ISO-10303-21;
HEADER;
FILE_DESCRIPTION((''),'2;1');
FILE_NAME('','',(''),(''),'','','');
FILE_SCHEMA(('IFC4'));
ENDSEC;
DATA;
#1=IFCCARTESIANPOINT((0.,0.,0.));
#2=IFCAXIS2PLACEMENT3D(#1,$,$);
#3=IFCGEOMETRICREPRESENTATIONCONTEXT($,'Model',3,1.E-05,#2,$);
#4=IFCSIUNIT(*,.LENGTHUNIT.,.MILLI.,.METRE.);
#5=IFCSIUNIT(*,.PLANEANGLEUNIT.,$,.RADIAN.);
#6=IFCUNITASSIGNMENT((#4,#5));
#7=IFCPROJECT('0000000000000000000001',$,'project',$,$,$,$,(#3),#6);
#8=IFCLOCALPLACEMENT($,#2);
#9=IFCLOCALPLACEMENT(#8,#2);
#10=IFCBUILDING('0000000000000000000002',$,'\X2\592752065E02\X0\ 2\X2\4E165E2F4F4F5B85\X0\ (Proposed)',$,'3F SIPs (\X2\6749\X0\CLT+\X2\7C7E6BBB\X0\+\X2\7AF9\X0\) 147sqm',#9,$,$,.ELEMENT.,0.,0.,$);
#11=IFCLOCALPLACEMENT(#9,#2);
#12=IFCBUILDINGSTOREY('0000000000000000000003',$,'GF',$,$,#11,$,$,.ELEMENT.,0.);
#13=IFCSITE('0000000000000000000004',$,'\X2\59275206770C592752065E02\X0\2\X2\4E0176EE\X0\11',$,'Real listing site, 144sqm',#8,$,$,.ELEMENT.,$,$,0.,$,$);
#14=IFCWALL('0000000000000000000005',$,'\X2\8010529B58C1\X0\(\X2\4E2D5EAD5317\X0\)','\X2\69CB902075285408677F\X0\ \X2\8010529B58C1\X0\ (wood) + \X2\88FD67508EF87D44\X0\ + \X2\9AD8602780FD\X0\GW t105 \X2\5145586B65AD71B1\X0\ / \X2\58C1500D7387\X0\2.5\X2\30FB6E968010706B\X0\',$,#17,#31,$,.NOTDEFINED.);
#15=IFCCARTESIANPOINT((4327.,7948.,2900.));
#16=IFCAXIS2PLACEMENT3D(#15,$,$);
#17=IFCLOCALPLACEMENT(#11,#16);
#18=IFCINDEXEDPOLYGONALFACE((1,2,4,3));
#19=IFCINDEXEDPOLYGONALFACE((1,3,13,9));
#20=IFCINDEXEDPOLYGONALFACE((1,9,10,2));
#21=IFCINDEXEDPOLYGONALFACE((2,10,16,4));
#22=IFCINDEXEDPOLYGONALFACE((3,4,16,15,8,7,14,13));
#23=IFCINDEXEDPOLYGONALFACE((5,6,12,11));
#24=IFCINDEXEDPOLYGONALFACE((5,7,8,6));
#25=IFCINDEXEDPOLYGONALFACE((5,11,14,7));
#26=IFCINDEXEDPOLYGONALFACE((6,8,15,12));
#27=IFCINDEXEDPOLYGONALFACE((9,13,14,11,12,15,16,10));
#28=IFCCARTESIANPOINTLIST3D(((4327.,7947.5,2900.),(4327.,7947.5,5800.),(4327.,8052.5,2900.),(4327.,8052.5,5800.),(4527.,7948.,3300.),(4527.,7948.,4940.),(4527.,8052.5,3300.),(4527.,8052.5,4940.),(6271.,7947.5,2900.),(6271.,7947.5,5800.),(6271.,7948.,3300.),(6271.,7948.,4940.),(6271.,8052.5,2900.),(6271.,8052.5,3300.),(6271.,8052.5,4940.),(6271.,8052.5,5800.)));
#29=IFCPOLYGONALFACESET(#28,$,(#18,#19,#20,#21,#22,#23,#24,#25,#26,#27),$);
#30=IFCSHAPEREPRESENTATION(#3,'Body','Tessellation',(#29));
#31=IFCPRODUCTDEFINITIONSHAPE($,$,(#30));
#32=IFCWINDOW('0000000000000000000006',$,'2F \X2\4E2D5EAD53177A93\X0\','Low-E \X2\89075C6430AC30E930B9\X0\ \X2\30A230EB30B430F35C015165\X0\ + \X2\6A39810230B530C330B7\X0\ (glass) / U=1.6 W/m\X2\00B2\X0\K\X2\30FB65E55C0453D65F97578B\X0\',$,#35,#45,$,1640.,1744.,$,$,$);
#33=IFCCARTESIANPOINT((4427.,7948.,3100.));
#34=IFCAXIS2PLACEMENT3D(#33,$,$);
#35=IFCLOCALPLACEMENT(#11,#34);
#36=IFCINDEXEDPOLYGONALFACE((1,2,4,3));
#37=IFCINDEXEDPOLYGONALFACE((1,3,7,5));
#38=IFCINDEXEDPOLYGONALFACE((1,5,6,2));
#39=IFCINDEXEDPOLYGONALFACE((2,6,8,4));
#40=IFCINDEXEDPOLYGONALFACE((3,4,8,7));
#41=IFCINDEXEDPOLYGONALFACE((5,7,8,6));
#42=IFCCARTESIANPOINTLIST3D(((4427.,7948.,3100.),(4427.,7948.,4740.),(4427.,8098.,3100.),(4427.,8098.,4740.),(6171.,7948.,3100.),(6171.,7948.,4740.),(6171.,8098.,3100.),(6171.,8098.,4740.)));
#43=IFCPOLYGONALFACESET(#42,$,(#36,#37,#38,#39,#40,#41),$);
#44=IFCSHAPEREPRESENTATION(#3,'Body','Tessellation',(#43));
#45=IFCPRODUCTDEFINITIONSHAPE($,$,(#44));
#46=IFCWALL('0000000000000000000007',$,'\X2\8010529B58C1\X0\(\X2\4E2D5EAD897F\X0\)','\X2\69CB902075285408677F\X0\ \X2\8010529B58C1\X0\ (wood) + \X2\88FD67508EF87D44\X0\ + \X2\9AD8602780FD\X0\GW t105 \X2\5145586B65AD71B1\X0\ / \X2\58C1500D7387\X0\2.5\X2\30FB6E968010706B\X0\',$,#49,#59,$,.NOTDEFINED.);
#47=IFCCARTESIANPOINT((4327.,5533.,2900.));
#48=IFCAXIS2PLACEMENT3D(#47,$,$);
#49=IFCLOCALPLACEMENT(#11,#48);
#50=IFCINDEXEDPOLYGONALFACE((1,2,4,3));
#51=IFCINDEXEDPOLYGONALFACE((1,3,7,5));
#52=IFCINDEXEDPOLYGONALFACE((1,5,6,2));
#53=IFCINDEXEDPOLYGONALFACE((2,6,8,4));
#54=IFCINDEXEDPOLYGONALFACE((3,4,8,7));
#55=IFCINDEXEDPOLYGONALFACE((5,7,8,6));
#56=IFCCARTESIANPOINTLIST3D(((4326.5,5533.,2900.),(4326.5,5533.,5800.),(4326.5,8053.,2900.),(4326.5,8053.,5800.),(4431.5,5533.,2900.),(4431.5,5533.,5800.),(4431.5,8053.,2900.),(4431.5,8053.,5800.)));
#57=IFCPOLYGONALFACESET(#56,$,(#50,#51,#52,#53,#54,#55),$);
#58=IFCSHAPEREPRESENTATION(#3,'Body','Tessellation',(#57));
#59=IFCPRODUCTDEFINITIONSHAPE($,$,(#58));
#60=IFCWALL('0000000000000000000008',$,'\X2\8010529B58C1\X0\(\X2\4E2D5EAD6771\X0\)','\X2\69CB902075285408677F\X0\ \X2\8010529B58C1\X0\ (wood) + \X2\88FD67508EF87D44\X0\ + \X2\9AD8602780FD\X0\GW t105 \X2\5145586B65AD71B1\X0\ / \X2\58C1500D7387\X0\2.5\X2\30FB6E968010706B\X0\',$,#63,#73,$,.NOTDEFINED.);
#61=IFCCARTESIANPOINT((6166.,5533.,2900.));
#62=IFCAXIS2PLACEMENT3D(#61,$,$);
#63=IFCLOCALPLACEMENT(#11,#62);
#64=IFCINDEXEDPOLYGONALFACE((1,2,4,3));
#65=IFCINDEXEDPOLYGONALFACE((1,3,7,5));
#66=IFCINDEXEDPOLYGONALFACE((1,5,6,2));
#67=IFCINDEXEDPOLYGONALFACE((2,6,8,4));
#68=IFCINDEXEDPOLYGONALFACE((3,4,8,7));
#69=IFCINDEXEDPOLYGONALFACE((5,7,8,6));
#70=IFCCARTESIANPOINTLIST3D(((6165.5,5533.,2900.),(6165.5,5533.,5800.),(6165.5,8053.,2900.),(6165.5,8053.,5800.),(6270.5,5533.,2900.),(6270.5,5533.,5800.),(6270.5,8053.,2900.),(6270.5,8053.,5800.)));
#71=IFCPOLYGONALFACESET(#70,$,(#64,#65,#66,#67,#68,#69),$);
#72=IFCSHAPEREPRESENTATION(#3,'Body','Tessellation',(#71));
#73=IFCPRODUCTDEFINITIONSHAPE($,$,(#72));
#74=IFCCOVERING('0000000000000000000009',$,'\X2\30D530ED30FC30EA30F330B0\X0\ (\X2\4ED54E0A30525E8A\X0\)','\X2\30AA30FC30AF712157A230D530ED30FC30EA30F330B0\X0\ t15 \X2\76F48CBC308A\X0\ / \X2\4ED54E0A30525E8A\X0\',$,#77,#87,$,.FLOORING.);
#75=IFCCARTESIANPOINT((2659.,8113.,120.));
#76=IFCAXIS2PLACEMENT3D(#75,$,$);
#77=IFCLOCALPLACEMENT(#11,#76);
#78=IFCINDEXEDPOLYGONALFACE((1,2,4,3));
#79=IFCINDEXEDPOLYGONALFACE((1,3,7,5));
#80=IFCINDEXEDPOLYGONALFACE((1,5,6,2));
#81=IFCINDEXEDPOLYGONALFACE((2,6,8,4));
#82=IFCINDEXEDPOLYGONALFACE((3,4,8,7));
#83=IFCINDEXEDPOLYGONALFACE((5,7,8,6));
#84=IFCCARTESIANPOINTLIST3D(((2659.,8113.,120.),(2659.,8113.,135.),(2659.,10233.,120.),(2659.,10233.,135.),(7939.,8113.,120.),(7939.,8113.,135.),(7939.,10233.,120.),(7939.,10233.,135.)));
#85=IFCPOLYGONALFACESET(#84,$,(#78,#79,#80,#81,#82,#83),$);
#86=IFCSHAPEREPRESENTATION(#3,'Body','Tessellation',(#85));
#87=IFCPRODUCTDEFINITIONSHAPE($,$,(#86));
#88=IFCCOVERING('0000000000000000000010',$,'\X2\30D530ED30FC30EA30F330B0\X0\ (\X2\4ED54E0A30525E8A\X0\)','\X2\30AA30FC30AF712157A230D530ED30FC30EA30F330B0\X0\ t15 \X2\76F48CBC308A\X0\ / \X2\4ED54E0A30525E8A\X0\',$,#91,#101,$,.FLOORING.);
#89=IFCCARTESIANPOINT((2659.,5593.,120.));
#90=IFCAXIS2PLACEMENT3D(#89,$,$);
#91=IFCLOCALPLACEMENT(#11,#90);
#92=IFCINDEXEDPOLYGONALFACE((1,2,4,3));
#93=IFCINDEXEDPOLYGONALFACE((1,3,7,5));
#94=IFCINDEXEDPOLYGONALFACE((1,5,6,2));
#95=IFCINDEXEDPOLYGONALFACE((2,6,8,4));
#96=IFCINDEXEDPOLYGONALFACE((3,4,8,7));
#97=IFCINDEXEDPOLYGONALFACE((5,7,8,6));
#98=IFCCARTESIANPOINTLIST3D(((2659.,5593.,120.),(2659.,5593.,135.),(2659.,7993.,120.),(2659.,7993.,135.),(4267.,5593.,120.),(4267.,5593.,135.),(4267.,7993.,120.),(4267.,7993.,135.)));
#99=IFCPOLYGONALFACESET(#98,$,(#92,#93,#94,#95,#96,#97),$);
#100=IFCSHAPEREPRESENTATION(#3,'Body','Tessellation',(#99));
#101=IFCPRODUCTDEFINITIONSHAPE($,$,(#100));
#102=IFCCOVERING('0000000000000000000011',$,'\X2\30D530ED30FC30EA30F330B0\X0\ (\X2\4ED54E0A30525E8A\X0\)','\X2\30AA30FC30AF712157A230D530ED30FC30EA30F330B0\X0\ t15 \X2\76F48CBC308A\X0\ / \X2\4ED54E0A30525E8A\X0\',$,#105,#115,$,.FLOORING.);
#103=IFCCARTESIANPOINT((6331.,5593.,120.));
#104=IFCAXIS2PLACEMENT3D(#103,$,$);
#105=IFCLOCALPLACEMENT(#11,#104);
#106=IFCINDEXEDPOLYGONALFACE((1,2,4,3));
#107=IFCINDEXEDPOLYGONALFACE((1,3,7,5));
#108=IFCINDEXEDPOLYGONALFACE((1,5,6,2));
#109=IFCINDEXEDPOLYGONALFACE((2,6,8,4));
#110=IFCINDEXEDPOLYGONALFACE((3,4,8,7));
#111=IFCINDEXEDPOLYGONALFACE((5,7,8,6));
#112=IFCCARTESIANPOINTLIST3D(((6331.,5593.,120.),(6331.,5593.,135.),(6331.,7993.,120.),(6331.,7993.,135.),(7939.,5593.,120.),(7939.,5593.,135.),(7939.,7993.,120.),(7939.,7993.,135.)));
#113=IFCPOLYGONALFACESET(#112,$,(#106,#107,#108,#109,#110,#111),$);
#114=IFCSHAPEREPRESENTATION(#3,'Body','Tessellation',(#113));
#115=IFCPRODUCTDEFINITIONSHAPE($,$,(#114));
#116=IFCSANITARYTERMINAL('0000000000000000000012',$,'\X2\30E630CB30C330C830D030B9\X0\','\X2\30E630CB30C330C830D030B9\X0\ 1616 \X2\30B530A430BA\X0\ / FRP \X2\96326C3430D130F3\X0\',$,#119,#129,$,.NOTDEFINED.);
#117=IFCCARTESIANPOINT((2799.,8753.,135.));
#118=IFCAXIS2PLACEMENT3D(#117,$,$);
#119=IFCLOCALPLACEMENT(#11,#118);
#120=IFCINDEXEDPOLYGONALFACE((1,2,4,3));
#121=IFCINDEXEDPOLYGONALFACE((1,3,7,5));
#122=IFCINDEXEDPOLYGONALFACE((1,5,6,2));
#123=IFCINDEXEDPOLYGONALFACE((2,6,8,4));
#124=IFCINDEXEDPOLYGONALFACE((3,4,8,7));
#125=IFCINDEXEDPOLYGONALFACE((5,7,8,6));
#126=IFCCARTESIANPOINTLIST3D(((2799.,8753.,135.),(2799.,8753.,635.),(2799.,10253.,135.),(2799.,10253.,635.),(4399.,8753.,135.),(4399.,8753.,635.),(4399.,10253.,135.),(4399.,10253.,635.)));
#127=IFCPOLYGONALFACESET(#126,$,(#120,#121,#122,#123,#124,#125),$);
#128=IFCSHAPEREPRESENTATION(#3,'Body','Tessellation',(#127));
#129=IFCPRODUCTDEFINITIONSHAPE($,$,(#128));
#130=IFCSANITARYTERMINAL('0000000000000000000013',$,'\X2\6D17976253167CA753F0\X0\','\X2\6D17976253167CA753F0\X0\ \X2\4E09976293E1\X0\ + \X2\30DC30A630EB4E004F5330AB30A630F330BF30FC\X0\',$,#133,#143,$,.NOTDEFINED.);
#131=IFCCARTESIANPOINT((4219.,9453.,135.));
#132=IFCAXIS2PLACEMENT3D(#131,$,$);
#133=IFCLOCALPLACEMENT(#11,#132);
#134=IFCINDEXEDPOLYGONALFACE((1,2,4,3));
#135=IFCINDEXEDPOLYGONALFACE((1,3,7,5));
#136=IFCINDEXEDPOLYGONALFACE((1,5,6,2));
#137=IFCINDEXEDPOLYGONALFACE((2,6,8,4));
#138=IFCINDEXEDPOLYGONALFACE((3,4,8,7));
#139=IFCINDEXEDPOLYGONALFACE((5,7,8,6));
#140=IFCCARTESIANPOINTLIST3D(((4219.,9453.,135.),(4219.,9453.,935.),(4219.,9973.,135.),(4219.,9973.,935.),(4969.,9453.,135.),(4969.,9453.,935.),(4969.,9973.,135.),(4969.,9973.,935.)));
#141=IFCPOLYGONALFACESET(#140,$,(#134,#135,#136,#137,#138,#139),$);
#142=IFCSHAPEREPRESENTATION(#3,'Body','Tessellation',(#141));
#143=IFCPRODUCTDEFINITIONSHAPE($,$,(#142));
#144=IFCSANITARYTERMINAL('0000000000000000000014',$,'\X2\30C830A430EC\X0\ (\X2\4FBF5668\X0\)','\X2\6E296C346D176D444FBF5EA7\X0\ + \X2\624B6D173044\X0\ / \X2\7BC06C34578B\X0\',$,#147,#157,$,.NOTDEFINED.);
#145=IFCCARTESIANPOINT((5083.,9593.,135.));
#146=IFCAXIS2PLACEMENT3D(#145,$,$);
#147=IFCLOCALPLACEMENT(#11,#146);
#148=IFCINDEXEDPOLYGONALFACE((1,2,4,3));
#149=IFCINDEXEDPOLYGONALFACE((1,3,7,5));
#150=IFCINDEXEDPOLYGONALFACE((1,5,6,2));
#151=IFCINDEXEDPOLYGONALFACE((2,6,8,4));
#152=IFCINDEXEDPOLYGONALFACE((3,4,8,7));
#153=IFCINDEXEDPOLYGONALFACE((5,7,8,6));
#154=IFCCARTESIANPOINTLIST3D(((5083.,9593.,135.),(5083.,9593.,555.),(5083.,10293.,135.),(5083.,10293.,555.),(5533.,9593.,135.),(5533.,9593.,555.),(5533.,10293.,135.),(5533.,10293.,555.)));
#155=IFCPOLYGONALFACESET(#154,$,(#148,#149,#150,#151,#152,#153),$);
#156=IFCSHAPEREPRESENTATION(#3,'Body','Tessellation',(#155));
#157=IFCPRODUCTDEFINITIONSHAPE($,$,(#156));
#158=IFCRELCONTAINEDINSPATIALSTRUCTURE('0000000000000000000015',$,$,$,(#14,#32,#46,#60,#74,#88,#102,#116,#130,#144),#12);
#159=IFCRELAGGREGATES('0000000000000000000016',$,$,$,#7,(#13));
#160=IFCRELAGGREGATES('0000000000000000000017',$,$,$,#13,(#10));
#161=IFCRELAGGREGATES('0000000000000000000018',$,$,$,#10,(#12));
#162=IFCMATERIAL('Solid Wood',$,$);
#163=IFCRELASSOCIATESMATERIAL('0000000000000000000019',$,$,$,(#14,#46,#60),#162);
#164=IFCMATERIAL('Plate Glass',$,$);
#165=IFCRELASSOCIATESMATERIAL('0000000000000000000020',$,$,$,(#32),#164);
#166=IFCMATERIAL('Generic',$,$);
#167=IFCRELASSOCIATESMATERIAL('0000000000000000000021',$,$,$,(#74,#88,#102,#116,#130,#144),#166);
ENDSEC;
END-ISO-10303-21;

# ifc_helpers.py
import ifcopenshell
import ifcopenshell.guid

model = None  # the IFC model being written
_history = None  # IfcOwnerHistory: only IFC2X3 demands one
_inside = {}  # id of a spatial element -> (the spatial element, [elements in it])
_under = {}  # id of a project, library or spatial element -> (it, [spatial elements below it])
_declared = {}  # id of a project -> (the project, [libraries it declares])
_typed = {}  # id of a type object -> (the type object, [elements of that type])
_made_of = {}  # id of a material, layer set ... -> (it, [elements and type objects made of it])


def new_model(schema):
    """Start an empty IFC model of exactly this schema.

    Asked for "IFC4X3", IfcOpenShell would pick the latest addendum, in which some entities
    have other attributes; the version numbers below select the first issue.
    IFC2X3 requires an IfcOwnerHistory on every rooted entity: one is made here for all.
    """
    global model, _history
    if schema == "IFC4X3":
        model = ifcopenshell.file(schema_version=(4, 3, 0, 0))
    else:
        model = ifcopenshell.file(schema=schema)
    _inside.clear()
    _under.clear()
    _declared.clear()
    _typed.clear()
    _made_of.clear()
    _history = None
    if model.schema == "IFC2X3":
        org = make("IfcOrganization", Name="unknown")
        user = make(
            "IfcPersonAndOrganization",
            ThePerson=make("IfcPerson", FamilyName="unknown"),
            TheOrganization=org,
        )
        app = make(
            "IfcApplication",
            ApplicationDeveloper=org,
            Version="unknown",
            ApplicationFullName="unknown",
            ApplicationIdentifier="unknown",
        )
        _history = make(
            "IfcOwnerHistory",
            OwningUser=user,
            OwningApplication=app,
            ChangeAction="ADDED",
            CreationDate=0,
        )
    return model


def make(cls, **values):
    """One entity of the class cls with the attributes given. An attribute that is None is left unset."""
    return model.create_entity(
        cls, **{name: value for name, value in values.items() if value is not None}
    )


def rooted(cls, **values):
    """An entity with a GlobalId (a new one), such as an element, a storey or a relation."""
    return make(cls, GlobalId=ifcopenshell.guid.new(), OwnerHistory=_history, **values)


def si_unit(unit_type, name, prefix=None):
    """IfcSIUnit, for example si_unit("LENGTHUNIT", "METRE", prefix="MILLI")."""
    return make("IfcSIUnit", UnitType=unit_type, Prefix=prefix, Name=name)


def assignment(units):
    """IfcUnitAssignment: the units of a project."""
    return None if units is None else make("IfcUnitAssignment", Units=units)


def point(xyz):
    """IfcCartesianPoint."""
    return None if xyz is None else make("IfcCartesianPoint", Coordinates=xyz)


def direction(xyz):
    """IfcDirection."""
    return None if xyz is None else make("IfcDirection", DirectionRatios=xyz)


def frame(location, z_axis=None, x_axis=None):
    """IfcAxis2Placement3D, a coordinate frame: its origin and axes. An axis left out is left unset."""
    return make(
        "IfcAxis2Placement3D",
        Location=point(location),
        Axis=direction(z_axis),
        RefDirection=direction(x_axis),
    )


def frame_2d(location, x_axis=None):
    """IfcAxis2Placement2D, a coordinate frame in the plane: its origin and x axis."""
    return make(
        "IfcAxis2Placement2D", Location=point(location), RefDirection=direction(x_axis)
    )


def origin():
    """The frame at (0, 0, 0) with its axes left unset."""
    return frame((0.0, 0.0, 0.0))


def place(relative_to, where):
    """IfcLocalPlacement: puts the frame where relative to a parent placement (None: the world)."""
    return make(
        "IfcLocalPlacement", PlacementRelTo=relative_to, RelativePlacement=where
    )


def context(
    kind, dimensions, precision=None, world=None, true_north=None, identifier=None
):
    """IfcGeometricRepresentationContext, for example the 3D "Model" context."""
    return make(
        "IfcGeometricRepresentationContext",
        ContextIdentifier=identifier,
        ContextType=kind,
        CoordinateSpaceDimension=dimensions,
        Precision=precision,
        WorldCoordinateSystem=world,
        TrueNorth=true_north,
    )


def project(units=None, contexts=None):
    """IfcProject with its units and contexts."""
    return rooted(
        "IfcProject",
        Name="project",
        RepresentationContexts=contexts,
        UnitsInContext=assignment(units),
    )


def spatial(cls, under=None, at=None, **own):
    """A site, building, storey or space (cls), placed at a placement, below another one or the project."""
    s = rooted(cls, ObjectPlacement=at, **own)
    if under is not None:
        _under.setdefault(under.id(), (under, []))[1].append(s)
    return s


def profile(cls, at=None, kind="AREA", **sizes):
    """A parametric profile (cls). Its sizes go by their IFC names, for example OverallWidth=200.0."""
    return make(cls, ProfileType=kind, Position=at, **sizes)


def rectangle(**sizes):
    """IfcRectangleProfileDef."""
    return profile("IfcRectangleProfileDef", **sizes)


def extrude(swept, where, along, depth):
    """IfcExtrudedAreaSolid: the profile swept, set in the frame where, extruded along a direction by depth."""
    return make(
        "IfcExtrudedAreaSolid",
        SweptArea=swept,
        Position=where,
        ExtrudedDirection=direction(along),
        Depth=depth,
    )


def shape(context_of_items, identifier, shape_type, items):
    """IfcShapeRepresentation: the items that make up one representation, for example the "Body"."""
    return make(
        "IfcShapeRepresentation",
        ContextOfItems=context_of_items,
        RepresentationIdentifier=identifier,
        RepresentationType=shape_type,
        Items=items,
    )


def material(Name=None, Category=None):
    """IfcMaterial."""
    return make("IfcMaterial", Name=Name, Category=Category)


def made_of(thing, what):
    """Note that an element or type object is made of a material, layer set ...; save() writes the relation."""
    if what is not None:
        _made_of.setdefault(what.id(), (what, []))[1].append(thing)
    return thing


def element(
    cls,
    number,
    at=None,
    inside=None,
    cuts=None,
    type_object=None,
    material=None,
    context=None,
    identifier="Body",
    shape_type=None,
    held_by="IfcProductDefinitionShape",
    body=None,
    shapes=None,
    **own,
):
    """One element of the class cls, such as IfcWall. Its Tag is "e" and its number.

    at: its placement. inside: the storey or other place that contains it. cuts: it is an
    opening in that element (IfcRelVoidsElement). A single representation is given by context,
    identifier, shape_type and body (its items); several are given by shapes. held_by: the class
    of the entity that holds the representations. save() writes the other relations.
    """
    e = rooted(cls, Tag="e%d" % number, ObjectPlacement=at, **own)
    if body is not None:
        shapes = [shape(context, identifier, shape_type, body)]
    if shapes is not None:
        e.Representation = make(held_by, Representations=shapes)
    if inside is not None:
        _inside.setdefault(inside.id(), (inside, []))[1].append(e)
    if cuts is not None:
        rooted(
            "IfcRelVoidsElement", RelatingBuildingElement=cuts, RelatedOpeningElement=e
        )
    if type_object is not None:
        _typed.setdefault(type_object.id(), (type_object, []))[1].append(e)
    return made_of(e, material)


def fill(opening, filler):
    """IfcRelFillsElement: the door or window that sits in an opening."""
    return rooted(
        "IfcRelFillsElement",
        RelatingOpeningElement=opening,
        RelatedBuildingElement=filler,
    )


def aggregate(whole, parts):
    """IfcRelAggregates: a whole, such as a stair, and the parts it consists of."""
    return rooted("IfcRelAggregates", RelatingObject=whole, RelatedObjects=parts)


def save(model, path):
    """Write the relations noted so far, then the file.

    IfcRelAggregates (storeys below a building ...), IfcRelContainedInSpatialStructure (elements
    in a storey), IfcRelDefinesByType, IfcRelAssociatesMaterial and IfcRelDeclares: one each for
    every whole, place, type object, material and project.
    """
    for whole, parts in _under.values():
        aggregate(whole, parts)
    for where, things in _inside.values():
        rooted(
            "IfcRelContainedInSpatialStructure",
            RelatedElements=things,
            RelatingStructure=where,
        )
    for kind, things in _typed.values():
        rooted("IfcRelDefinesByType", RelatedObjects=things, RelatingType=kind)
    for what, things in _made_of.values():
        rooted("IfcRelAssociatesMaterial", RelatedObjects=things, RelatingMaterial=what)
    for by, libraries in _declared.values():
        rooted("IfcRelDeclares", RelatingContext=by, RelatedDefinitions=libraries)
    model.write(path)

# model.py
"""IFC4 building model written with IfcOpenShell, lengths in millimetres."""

from ifc_helpers import new_model, si_unit, frame, frame_2d, origin, place, context, project, spatial, rectangle, extrude, material, element, fill, save


model = new_model("IFC4")

# Units and contexts
model_context = context("Model", 3, precision=1e-05, world=origin())
ifc_project = project(units=[si_unit("LENGTHUNIT", "METRE", prefix="MILLI"), si_unit("PLANEANGLEUNIT", "RADIAN")], contexts=[model_context])

# Site, building, storey
site_placement = place(None, origin())
site = spatial("IfcSite", under=ifc_project, at=site_placement, Name="大分県大分市2丁目11", ObjectType="Real listing site, 144sqm", CompositionType="ELEMENT", RefElevation=0.0)
building_placement = place(site_placement, origin())
building = spatial("IfcBuilding", under=site, at=building_placement, Name="大分市 2世帯住宅 (Proposed)", ObjectType="3F SIPs (杉CLT+籾殻+竹) 147sqm", CompositionType="ELEMENT", ElevationOfRefHeight=0.0, ElevationOfTerrain=0.0)
storey_placement = place(building_placement, origin())
storey = spatial("IfcBuildingStorey", under=building, at=storey_placement, Name="GF", CompositionType="ELEMENT", Elevation=0.0)

# Shared definitions
ifc_material_1 = material(Name="Solid Wood")

# Shared definitions
ifc_material_2 = material(Name="Plate Glass")

# Wall, opening, window
wall_1_placement = place(storey_placement, frame((4327.0, 7948.0, 2900.0)))
wall_1 = element("IfcWall", 1, at=wall_1_placement, inside=storey, material=ifc_material_1, Name="耐力壁(中庭北)", Description="構造用合板 耐力壁 (wood) + 製材軸組 + 高性能GW t105 充填断熱 / 壁倍率2.5・準耐火", PredefinedType="NOTDEFINED", context=model_context, shape_type="SweptSolid", body=[
    extrude(rectangle(XDim=1944.0, YDim=105.0, at=frame_2d((972.0, 52.0))), frame((4327.0, 7948.0, 2900.0)), (0.0, 0.0, 1.0), 2900.0),
])
opening_1_placement = place(storey_placement, frame((4427.0, 7948.0, 3100.0)))
opening_1 = element("IfcOpeningElement", 2, at=opening_1_placement, cuts=wall_1, PredefinedType="NOTDEFINED", context=model_context, shape_type="SweptSolid", body=[
    extrude(rectangle(XDim=1744.0, YDim=150.0, at=frame_2d((872.0, 75.0))), frame((4427.0, 7948.0, 3100.0)), (0.0, 0.0, 1.0), 1640.0),
])
window_1_placement = place(storey_placement, frame((4427.0, 7948.0, 3100.0)))
window_1 = element("IfcWindow", 3, at=window_1_placement, inside=storey, material=ifc_material_2, Name="2F 中庭北窓", Description="Low-E 複層ガラス アルゴン封入 + 樹脂サッシ (glass) / U=1.6 W/m²K・日射取得型", OverallHeight=1640.0, OverallWidth=1744.0, context=model_context, shape_type="SweptSolid", body=[
    extrude(rectangle(XDim=1744.0, YDim=150.0, at=frame_2d((872.0, 75.0))), frame((4427.0, 7948.0, 3100.0)), (0.0, 0.0, 1.0), 1640.0),
])
fill(opening_1, window_1)

# Walls
wall_2_placement = place(storey_placement, frame((4327.0, 5533.0, 2900.0)))
element("IfcWall", 4, at=wall_2_placement, inside=storey, material=ifc_material_1, Name="耐力壁(中庭西)", Description="構造用合板 耐力壁 (wood) + 製材軸組 + 高性能GW t105 充填断熱 / 壁倍率2.5・準耐火", PredefinedType="NOTDEFINED", context=model_context, shape_type="SweptSolid", body=[
    extrude(rectangle(XDim=105.0, YDim=2520.0, at=frame_2d((52.0, 1260.0))), frame((4327.0, 5533.0, 2900.0)), (0.0, 0.0, 1.0), 2900.0),
])
wall_3_placement = place(storey_placement, frame((6166.0, 5533.0, 2900.0)))
element("IfcWall", 5, at=wall_3_placement, inside=storey, material=ifc_material_1, Name="耐力壁(中庭東)", Description="構造用合板 耐力壁 (wood) + 製材軸組 + 高性能GW t105 充填断熱 / 壁倍率2.5・準耐火", PredefinedType="NOTDEFINED", context=model_context, shape_type="SweptSolid", body=[
    extrude(rectangle(XDim=105.0, YDim=2520.0, at=frame_2d((52.0, 1260.0))), frame((6166.0, 5533.0, 2900.0)), (0.0, 0.0, 1.0), 2900.0),
])

# Coverings
ifc_material_3 = material(Name="Generic")
covering_1_placement = place(storey_placement, frame((2659.0, 8113.0, 120.0)))
element("IfcCovering", 6, at=covering_1_placement, inside=storey, material=ifc_material_3, Name="フローリング (仕上げ床)", Description="オーク無垢フローリング t15 直貼り / 仕上げ床", PredefinedType="FLOORING", context=model_context, shape_type="SweptSolid", body=[
    extrude(rectangle(XDim=5280.0, YDim=2120.0, at=frame_2d((2640.0, 1060.0))), frame((2659.0, 8113.0, 120.0)), (0.0, 0.0, 1.0), 15.0),
])
covering_2_placement = place(storey_placement, frame((2659.0, 5593.0, 120.0)))
element("IfcCovering", 7, at=covering_2_placement, inside=storey, material=ifc_material_3, Name="フローリング (仕上げ床)", Description="オーク無垢フローリング t15 直貼り / 仕上げ床", PredefinedType="FLOORING", context=model_context, shape_type="SweptSolid", body=[
    extrude(rectangle(XDim=1608.0, YDim=2400.0, at=frame_2d((804.0, 1200.0))), frame((2659.0, 5593.0, 120.0)), (0.0, 0.0, 1.0), 15.0),
])
covering_3_placement = place(storey_placement, frame((6331.0, 5593.0, 120.0)))
element("IfcCovering", 8, at=covering_3_placement, inside=storey, material=ifc_material_3, Name="フローリング (仕上げ床)", Description="オーク無垢フローリング t15 直貼り / 仕上げ床", PredefinedType="FLOORING", context=model_context, shape_type="SweptSolid", body=[
    extrude(rectangle(XDim=1608.0, YDim=2400.0, at=frame_2d((804.0, 1200.0))), frame((6331.0, 5593.0, 120.0)), (0.0, 0.0, 1.0), 15.0),
])

# Sanitary terminals
sanitary_terminal_1_placement = place(storey_placement, frame((2799.0, 8753.0, 135.0)))
element("IfcSanitaryTerminal", 9, at=sanitary_terminal_1_placement, inside=storey, material=ifc_material_3, Name="ユニットバス", Description="ユニットバス 1616 サイズ / FRP 防水パン", PredefinedType="NOTDEFINED", context=model_context, shape_type="SweptSolid", body=[
    extrude(rectangle(XDim=1600.0, YDim=1500.0, at=frame_2d((800.0, 750.0))), frame((2799.0, 8753.0, 135.0)), (0.0, 0.0, 1.0), 500.0),
])
sanitary_terminal_2_placement = place(storey_placement, frame((4219.0, 9453.0, 135.0)))
element("IfcSanitaryTerminal", 10, at=sanitary_terminal_2_placement, inside=storey, material=ifc_material_3, Name="洗面化粧台", Description="洗面化粧台 三面鏡 + ボウル一体カウンター", PredefinedType="NOTDEFINED", context=model_context, shape_type="SweptSolid", body=[
    extrude(rectangle(XDim=750.0, YDim=520.0, at=frame_2d((375.0, 260.0))), frame((4219.0, 9453.0, 135.0)), (0.0, 0.0, 1.0), 800.0),
])
sanitary_terminal_3_placement = place(storey_placement, frame((5083.0, 9593.0, 135.0)))
element("IfcSanitaryTerminal", 11, at=sanitary_terminal_3_placement, inside=storey, material=ifc_material_3, Name="トイレ (便器)", Description="温水洗浄便座 + 手洗い / 節水型", PredefinedType="NOTDEFINED", context=model_context, shape_type="SweptSolid", body=[
    extrude(rectangle(XDim=450.0, YDim=700.0, at=frame_2d((225.0, 350.0))), frame((5083.0, 9593.0, 135.0)), (0.0, 0.0, 1.0), 420.0),
])

save(model, "model.ifc")
